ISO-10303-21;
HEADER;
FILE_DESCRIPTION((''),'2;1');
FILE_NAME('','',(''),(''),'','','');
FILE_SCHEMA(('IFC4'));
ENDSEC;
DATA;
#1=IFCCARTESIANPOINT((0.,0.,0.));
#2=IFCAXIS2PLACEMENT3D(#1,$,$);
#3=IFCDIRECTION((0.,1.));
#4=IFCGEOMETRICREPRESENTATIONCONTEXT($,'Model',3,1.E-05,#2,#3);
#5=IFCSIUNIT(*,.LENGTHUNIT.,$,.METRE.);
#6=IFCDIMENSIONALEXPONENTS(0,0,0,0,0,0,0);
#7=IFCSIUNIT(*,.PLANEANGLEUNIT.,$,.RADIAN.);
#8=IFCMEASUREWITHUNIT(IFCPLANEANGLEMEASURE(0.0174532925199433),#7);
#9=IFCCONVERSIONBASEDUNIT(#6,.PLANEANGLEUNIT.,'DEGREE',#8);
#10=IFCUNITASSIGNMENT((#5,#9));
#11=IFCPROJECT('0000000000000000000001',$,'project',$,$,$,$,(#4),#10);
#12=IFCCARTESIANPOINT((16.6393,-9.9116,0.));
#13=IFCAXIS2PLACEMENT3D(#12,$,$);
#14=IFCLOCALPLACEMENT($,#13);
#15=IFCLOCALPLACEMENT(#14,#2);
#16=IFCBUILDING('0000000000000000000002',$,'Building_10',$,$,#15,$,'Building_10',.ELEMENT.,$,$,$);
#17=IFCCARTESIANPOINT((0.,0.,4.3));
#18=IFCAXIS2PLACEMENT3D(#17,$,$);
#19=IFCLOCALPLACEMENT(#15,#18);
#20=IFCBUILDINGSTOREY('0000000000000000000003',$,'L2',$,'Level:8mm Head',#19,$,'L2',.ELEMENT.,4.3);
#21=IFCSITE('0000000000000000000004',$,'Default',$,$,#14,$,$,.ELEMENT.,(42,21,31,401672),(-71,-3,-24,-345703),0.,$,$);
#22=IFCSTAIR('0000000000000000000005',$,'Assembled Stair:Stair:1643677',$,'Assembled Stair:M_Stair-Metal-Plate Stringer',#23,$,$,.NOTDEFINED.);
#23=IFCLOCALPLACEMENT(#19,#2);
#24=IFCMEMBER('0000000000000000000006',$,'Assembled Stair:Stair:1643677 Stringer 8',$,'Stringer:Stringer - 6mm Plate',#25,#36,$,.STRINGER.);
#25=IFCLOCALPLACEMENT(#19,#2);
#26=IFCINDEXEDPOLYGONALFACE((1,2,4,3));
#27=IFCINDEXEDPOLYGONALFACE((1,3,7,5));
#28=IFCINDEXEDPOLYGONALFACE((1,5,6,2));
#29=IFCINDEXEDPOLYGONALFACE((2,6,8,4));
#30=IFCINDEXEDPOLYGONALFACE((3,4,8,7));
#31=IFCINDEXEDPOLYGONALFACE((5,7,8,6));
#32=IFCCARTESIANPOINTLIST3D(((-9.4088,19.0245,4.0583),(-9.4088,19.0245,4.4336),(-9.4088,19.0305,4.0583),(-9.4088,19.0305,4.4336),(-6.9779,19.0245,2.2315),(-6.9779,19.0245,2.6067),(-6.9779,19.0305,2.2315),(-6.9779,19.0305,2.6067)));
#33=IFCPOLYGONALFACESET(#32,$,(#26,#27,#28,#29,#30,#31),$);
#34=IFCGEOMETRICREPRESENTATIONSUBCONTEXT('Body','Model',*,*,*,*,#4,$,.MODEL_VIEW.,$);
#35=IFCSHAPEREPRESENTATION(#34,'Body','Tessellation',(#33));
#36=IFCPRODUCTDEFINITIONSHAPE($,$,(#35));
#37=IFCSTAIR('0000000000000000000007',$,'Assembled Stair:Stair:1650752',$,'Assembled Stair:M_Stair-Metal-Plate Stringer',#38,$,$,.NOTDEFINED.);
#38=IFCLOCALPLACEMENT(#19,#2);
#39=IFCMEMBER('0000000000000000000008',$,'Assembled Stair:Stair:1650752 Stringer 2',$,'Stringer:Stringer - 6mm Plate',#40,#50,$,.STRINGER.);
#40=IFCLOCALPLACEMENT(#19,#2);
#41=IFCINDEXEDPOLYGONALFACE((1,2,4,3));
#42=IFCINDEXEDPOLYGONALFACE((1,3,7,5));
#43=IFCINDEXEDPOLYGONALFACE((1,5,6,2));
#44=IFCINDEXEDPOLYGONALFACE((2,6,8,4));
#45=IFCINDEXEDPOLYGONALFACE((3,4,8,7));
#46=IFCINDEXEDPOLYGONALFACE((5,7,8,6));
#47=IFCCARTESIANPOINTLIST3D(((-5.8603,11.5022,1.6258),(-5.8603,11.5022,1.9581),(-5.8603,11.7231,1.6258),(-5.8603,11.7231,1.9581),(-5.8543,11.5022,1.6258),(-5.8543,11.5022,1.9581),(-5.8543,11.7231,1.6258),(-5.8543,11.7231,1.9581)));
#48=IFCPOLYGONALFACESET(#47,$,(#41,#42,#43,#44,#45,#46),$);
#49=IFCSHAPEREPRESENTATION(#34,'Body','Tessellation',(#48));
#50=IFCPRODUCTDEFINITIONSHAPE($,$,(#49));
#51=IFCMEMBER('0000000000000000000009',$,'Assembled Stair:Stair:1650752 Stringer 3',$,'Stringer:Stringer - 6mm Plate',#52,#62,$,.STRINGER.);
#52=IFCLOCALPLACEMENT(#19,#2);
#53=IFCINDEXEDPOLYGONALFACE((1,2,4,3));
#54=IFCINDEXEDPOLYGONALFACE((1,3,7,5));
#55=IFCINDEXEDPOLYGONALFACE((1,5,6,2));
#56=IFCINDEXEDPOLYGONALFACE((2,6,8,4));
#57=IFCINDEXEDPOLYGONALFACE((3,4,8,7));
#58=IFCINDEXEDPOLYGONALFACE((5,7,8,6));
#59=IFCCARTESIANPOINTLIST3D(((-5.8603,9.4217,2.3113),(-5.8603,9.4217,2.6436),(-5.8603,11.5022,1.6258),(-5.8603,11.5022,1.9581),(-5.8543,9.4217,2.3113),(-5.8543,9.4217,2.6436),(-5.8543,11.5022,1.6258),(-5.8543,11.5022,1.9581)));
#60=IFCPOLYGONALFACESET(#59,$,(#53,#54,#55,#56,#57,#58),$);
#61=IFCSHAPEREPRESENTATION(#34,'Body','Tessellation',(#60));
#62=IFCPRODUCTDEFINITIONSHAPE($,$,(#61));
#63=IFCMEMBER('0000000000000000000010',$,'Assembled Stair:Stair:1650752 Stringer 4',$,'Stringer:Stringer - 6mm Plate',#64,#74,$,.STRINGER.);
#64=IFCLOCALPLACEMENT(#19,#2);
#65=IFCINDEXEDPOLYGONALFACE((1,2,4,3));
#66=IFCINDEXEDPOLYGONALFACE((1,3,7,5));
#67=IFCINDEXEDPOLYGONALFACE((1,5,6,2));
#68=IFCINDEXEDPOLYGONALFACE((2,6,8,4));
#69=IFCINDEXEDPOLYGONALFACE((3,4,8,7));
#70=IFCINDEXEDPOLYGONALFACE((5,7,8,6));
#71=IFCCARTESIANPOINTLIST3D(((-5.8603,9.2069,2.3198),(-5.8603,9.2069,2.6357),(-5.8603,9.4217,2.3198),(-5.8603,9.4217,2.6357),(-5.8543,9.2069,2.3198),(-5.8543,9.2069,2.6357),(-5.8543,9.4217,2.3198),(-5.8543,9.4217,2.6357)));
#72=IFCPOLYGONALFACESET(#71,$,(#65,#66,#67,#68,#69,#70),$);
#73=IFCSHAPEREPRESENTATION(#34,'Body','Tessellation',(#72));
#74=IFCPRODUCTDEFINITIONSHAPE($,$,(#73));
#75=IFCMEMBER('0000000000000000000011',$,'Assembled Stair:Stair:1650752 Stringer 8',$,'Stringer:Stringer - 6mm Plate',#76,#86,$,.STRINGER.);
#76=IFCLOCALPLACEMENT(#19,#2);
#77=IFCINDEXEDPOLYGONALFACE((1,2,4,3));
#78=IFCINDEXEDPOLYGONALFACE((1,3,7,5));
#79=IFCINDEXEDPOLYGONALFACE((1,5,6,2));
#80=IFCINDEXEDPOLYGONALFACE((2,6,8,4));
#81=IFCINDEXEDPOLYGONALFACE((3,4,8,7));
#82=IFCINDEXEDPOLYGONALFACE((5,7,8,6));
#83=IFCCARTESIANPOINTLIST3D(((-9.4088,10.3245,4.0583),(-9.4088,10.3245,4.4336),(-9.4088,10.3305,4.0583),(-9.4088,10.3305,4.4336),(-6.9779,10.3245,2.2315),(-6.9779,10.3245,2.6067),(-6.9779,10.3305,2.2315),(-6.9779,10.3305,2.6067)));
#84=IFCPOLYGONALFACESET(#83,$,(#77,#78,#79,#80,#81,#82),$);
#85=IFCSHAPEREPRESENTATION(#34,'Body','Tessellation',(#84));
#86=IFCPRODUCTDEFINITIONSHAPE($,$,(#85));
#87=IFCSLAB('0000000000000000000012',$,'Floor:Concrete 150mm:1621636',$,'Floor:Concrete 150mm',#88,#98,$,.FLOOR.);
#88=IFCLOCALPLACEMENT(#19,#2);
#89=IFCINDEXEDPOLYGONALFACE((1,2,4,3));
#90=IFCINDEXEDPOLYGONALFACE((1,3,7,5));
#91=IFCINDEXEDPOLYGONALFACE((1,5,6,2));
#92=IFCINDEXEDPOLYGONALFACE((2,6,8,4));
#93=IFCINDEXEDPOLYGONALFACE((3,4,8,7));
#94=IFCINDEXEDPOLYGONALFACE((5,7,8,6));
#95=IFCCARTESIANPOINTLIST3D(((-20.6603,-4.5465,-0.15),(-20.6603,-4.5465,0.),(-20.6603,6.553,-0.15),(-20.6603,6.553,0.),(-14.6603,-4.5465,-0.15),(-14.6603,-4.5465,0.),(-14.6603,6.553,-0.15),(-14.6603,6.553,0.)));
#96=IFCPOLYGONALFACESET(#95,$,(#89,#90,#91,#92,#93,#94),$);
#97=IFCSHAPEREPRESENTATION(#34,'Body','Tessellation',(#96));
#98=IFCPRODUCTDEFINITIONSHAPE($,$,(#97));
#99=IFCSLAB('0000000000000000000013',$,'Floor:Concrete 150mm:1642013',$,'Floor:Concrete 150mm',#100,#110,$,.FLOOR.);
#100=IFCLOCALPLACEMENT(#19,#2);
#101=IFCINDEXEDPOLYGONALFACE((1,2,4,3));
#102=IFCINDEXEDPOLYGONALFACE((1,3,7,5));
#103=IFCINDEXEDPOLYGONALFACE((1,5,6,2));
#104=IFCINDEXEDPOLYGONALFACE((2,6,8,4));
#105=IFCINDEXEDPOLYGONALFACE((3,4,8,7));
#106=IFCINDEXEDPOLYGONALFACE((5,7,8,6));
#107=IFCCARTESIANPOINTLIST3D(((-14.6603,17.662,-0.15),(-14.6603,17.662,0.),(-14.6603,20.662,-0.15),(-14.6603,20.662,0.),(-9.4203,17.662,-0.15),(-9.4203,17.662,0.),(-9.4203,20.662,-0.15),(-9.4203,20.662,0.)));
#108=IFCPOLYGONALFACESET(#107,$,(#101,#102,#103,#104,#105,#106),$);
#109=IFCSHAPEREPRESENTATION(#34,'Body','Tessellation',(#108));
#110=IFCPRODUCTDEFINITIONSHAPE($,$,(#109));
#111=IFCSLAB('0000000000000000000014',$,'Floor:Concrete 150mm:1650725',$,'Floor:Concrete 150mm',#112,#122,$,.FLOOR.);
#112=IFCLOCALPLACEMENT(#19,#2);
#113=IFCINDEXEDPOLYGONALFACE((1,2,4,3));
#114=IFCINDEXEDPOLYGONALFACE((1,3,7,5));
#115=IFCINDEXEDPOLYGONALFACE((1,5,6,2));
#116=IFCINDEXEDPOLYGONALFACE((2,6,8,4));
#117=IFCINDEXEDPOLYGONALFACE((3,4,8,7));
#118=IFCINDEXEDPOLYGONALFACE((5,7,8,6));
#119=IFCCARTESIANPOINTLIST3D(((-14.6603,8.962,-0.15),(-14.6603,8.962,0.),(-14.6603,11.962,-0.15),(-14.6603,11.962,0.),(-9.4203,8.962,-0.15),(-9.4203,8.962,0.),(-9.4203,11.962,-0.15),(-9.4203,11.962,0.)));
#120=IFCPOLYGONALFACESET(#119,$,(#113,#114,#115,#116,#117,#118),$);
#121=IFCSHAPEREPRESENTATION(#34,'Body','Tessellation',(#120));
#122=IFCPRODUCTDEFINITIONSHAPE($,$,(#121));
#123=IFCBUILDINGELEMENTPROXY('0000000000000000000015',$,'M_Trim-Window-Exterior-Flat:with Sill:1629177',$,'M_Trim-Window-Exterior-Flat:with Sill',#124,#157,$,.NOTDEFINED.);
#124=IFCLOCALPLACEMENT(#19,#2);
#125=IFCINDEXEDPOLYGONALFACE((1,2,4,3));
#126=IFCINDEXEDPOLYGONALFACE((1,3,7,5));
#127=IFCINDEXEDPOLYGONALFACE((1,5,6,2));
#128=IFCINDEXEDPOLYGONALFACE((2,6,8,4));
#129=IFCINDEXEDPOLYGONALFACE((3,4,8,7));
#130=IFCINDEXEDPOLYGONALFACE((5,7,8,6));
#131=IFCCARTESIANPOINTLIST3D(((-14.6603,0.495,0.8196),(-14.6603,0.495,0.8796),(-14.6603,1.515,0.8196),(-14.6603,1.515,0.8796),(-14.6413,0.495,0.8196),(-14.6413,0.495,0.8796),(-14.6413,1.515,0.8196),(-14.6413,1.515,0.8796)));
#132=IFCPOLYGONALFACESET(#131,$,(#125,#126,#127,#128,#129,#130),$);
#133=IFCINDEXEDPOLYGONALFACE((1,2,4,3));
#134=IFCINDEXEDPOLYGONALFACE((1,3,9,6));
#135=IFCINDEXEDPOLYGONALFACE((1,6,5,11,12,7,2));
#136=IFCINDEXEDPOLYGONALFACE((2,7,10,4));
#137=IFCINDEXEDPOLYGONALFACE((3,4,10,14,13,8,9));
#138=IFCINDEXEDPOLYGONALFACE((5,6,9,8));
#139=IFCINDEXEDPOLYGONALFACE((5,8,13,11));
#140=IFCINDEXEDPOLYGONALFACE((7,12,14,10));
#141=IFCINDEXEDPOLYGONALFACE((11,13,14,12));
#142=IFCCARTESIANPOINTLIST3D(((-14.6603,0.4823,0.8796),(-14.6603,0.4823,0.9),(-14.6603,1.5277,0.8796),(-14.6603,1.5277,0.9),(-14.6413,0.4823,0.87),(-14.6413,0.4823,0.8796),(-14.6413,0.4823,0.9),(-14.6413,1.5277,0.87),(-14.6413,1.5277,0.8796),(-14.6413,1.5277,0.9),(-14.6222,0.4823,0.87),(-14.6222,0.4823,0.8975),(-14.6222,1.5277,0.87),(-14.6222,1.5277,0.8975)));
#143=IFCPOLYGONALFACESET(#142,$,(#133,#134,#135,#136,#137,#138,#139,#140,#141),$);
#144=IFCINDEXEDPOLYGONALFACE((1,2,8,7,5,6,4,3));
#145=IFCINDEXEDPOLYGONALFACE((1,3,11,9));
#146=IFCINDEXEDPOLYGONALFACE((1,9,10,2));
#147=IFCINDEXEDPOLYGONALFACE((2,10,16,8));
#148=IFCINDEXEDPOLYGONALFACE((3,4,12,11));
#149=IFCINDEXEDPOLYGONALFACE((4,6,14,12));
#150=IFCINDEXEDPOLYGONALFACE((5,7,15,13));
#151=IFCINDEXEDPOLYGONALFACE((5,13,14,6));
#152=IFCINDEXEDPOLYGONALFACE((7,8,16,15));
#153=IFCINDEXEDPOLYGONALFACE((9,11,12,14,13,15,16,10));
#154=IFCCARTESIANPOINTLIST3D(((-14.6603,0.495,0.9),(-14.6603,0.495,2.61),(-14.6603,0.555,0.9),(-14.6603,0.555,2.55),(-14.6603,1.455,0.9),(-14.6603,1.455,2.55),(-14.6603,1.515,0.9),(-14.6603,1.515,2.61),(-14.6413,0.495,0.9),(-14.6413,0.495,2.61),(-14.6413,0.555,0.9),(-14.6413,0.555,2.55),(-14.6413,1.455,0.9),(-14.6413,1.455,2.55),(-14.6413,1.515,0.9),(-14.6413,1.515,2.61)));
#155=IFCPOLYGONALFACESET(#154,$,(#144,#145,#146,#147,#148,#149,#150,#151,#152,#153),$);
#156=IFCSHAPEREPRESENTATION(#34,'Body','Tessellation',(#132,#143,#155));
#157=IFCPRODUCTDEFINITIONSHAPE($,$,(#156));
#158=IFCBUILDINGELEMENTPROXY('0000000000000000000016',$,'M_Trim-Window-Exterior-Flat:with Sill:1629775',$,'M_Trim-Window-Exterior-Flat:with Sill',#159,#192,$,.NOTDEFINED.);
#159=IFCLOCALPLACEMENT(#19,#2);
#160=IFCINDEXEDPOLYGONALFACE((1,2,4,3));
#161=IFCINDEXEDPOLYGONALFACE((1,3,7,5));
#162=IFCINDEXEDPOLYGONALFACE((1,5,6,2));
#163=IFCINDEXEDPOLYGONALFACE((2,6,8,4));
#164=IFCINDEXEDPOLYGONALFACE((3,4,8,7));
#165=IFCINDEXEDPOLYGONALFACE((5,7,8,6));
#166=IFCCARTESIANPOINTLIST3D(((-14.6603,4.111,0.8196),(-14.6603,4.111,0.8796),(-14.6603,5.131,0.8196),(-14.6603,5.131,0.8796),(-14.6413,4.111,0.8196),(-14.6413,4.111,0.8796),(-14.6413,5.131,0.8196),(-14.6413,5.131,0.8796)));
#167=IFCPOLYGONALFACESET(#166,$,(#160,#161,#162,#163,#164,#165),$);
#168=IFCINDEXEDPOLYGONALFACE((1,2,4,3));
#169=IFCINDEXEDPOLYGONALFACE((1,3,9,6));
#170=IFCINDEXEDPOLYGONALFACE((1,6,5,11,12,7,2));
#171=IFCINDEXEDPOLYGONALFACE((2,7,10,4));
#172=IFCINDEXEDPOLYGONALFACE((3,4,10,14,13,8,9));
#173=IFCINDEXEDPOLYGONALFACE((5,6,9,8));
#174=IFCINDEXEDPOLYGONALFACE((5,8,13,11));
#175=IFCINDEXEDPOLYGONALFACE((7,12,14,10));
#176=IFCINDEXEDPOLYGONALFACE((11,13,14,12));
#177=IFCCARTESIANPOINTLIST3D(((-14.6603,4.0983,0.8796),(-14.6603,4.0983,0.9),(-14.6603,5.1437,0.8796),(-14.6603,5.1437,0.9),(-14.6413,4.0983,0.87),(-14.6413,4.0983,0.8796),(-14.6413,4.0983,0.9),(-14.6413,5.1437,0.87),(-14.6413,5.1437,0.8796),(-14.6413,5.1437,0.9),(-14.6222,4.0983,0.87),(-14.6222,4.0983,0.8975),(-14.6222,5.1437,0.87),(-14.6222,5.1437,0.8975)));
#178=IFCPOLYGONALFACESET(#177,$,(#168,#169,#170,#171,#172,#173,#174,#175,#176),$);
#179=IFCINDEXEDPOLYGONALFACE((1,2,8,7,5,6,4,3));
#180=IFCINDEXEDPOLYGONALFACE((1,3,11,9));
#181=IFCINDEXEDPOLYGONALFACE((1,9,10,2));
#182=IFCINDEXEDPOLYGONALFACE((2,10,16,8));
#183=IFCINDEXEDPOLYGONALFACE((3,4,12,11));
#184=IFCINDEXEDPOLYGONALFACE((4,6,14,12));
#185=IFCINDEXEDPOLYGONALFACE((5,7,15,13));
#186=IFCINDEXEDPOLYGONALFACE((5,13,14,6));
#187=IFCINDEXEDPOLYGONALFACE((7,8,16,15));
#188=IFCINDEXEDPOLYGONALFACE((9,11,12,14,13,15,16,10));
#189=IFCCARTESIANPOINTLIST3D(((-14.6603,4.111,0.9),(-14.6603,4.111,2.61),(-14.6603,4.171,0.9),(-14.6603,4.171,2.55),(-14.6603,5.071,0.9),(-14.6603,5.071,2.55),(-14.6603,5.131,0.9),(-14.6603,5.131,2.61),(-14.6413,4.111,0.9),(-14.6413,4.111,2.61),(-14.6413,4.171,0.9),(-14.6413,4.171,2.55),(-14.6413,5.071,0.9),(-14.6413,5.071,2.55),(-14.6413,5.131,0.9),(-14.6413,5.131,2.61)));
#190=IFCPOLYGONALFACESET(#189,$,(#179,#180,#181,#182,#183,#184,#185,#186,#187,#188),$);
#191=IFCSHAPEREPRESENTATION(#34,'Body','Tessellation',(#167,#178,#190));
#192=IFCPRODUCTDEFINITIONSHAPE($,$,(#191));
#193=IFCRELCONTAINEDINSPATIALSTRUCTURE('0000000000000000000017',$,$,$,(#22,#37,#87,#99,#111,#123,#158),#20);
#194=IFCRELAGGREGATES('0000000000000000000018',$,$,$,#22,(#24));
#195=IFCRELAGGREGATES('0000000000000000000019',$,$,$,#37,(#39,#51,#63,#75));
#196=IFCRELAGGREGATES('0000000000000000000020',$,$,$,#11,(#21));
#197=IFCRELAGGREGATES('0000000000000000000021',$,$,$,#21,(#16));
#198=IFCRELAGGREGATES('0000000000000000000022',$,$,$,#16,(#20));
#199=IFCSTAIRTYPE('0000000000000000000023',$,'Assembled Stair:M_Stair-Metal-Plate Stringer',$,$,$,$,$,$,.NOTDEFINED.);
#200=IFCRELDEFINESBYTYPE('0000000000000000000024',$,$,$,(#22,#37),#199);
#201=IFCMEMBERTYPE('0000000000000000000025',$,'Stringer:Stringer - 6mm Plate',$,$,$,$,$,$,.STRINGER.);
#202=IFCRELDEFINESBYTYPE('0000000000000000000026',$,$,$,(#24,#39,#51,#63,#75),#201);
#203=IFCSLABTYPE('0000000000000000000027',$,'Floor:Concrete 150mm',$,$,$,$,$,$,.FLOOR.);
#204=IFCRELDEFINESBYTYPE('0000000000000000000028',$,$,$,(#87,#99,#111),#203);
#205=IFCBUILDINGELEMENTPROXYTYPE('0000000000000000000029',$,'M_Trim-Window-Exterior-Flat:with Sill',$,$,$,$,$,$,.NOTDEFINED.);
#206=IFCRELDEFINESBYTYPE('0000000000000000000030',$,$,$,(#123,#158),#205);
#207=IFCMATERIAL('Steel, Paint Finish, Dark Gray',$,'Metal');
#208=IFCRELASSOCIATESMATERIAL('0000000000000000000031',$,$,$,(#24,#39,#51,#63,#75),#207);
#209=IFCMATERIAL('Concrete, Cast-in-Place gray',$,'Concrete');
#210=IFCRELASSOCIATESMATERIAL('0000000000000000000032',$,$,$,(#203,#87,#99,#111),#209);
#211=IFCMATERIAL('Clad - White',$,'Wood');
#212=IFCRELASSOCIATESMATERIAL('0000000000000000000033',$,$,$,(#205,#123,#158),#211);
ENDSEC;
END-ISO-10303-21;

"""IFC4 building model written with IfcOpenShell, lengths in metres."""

from ifc_helpers import new_model, entity, si_unit, converted_unit, direction, frame, origin, place, context, subcontext, project, spatial, indexed_curve, outline, extrude, source, transform, mapped, material, type_object, type_shapes, element, aggregate, save


model = new_model("IFC4")

# Units and contexts
model_context = context("Model", 3, precision=1e-05, world=origin(), true_north=direction((0.0, 1.0)))
body_context = subcontext(model_context, "Body", "Model", "MODEL_VIEW")
ifc_project = project(units=[si_unit("LENGTHUNIT", "METRE"), converted_unit("PLANEANGLEUNIT", "DEGREE", entity("IfcPlaneAngleMeasure", 0.0174532925199433), si_unit("PLANEANGLEUNIT", "RADIAN"), dimensions=[0, 0, 0, 0, 0, 0, 0])], contexts=[model_context])

# Site, building, storey
site_placement = place(None, frame((16.6393, -9.9116, 0.0)))
site = spatial("IfcSite", under=ifc_project, at=site_placement, Name="Default", CompositionType="ELEMENT", RefLatitude=(42, 21, 31, 401672), RefLongitude=(-71, -3, -24, -345703), RefElevation=0.0)
building_placement = place(site_placement, origin())
building = spatial("IfcBuilding", under=site, at=building_placement, Name="Building_10", LongName="Building_10", CompositionType="ELEMENT")
storey_placement = place(building_placement, frame((0.0, 0.0, 4.3)))
storey = spatial("IfcBuildingStorey", under=building, at=storey_placement, Name="L2", ObjectType="Level:8mm Head", LongName="L2", CompositionType="ELEMENT", Elevation=4.3)

# Shared definitions
ifc_material_1 = material(Name="Concrete, Cast-in-Place gray", Category="Concrete")

# Stairs, members
stair_type = type_object("IfcStairType", Name="Assembled Stair:M_Stair-Metal-Plate Stringer", PredefinedType="NOTDEFINED")
stair_1_placement = place(storey_placement, origin())
stair_1 = element("IfcStair", 1, at=stair_1_placement, inside=storey, type_object=stair_type, Name="Assembled Stair:Stair:1643677", ObjectType="Assembled Stair:M_Stair-Metal-Plate Stringer", PredefinedType="NOTDEFINED")
ifc_material_2 = material(Name="Steel, Paint Finish, Dark Gray", Category="Metal")
member_type = type_object("IfcMemberType", Name="Stringer:Stringer - 6mm Plate", PredefinedType="STRINGER")
member_1_placement = place(stair_1_placement, origin())
member_1 = element("IfcMember", 2, at=member_1_placement, type_object=member_type, material=ifc_material_2, Name="Assembled Stair:Stair:1643677 Stringer 8", ObjectType="Stringer:Stringer - 6mm Plate", PredefinedType="STRINGER", context=body_context, shape_type="SweptSolid", body=[
    extrude(outline(indexed_curve([(-1.6331, -0.15), (1.4077, -0.15), (1.6331, 0.15), (-1.4077, 0.15), (-1.6331, -0.15)], self_intersect=False)), frame((-8.1933, 19.0245, 3.3325), z_axis=(0.0, 1.0, 0.0), x_axis=(-0.799415, 0.0, 0.600779)), (0.0, 0.0, 1.0), 0.006),
])
aggregate(stair_1, [member_1])
stair_2_placement = place(storey_placement, origin())
stair_2 = element("IfcStair", 3, at=stair_2_placement, inside=storey, type_object=stair_type, Name="Assembled Stair:Stair:1650752", ObjectType="Assembled Stair:M_Stair-Metal-Plate Stringer", PredefinedType="NOTDEFINED")
member_2_placement = place(stair_2_placement, origin())
member_2 = element("IfcMember", 4, at=member_2_placement, type_object=member_type, material=ifc_material_2, Name="Assembled Stair:Stair:1650752 Stringer 2", ObjectType="Stringer:Stringer - 6mm Plate", PredefinedType="STRINGER", context=body_context, shape_type="SweptSolid", body=[
    extrude(outline(indexed_curve([(-0.1104, -0.003), (0.1104, -0.003), (0.1104, 0.003), (-0.1104, 0.003), (-0.1104, -0.003)], self_intersect=False)), frame((-5.8573, 11.6126, 1.6258), z_axis=(0.0, 0.0, 1.0), x_axis=(0.0, -1.0, 0.0)), (0.0, 0.0, 1.0), 0.3323),
])
member_3_placement = place(stair_2_placement, origin())
member_3 = element("IfcMember", 5, at=member_3_placement, type_object=member_type, material=ifc_material_2, Name="Assembled Stair:Stair:1650752 Stringer 3", ObjectType="Stringer:Stringer - 6mm Plate", PredefinedType="STRINGER", context=body_context, shape_type="SweptSolid", body=[
    extrude(outline(indexed_curve([(-1.0433, -0.1578), (1.1473, -0.1578), (1.0433, 0.1578), (-1.1473, 0.1578), (-1.0433, -0.1578)], self_intersect=False)), frame((-5.8603, 10.462, 2.1347), z_axis=(1.0, 0.0, 0.0), x_axis=(0.0, -0.949774, 0.312936)), (0.0, 0.0, 1.0), 0.006),
])
member_4_placement = place(stair_2_placement, origin())
member_4 = element("IfcMember", 6, at=member_4_placement, type_object=member_type, material=ifc_material_2, Name="Assembled Stair:Stair:1650752 Stringer 4", ObjectType="Stringer:Stringer - 6mm Plate", PredefinedType="STRINGER", context=body_context, shape_type="SweptSolid", body=[
    extrude(outline(indexed_curve([(-0.1074, -0.003), (0.1074, -0.003), (0.1074, 0.003), (-0.1074, 0.003), (-0.1074, -0.003)], self_intersect=False)), frame((-5.8573, 9.3143, 2.3198), z_axis=(0.0, 0.0, 1.0), x_axis=(0.0, -1.0, 0.0)), (0.0, 0.0, 1.0), 0.3159),
])
member_5_placement = place(stair_2_placement, origin())
member_5 = element("IfcMember", 7, at=member_5_placement, type_object=member_type, material=ifc_material_2, Name="Assembled Stair:Stair:1650752 Stringer 8", ObjectType="Stringer:Stringer - 6mm Plate", PredefinedType="STRINGER", context=body_context, shape_type="SweptSolid", body=[
    extrude(outline(indexed_curve([(-1.6331, -0.15), (1.4077, -0.15), (1.6331, 0.15), (-1.4077, 0.15), (-1.6331, -0.15)], self_intersect=False)), frame((-8.1933, 10.3245, 3.3325), z_axis=(0.0, 1.0, 0.0), x_axis=(-0.799415, 0.0, 0.600779)), (0.0, 0.0, 1.0), 0.006),
])
aggregate(stair_2, [member_2, member_3, member_4, member_5])

# Slabs
slab_type = type_object("IfcSlabType", Name="Floor:Concrete 150mm", PredefinedType="FLOOR", material=ifc_material_1)
slab_1_placement = place(storey_placement, origin())
element("IfcSlab", 8, at=slab_1_placement, inside=storey, type_object=slab_type, material=ifc_material_1, Name="Floor:Concrete 150mm:1621636", ObjectType="Floor:Concrete 150mm", PredefinedType="FLOOR", context=body_context, shape_type="SweptSolid", body=[
    extrude(outline(indexed_curve([(-5.5498, -3.0), (5.5498, -3.0), (5.5498, 3.0), (-5.5498, 3.0), (-5.5498, -3.0)], self_intersect=False)), frame((-17.6603, 1.0032, 0.0), z_axis=(0.0, 0.0, -1.0), x_axis=(0.0, 1.0, 0.0)), (0.0, 0.0, 1.0), 0.15),
])
slab_2_placement = place(storey_placement, origin())
element("IfcSlab", 9, at=slab_2_placement, inside=storey, type_object=slab_type, material=ifc_material_1, Name="Floor:Concrete 150mm:1642013", ObjectType="Floor:Concrete 150mm", PredefinedType="FLOOR", context=body_context, shape_type="SweptSolid", body=[
    extrude(outline(indexed_curve([(-1.5, -2.62), (1.5, -2.62), (1.5, 2.62), (-1.5, 2.62), (-1.5, -2.62)], self_intersect=False)), frame((-12.0403, 19.162, 0.0), z_axis=(0.0, 0.0, -1.0), x_axis=(0.0, 1.0, 0.0)), (0.0, 0.0, 1.0), 0.15),
])
slab_3_placement = place(storey_placement, origin())
element("IfcSlab", 10, at=slab_3_placement, inside=storey, type_object=slab_type, material=ifc_material_1, Name="Floor:Concrete 150mm:1650725", ObjectType="Floor:Concrete 150mm", PredefinedType="FLOOR", context=body_context, shape_type="SweptSolid", body=[
    extrude(outline(indexed_curve([(-1.5, -2.62), (1.5, -2.62), (1.5, 2.62), (-1.5, 2.62), (-1.5, -2.62)], self_intersect=False)), frame((-12.0403, 10.462, 0.0), z_axis=(0.0, 0.0, -1.0), x_axis=(0.0, 1.0, 0.0)), (0.0, 0.0, 1.0), 0.15),
])

# Building element proxies
ifc_material_3 = material(Name="Clad - White", Category="Wood")
building_element_proxy_type_1 = type_object("IfcBuildingElementProxyType", Name="M_Trim-Window-Exterior-Flat:with Sill", PredefinedType="NOTDEFINED", material=ifc_material_3)
shared_shape_1 = source(origin(), body_context, "Body", "SweptSolid", [
    extrude(outline(indexed_curve([(-0.51, -0.03), (0.51, -0.03), (0.51, 0.03), (-0.51, 0.03), (-0.51, -0.03)], self_intersect=False)), frame((0.0, -1.7004, 0.0), z_axis=(0.0, 0.0, 1.0), x_axis=(-1.0, 0.0, 0.0)), (0.0, 0.0, 1.0), 0.0191),
    extrude(outline(indexed_curve([(-0.019, -0.0152), (0.0, -0.0152), (0.0, -0.0057), (0.019, -0.0057), (0.019, 0.0148), (0.0, 0.0148), (-0.019, 0.0123), (-0.019, -0.0152)], self_intersect=False)), frame((-0.5227, -1.6648, 0.019), z_axis=(1.0, 0.0, 0.0), x_axis=(0.0, 0.0, -1.0)), (0.0, 0.0, 1.0), 1.0454),
    extrude(outline(indexed_curve([(-0.87, -0.51), (0.84, -0.51), (0.84, -0.45), (-0.81, -0.45), (-0.81, 0.45), (0.84, 0.45), (0.84, 0.51), (-0.87, 0.51), (-0.87, -0.51)], self_intersect=False)), frame((0.0, -0.81, 0.0), z_axis=(0.0, 0.0, 1.0), x_axis=(0.0, -1.0, 0.0)), (0.0, 0.0, 1.0), 0.0191),
])
type_shapes(building_element_proxy_type_1, [shared_shape_1])
for number, where, z_axis, x_axis, name in (
    (11, (-14.6603, 1.005, 2.55), (1.0, 0.0, 0.0), (0.0, 1.0, 0.0), "M_Trim-Window-Exterior-Flat:with Sill:1629177"),
    (12, (-14.6603, 4.621, 2.55), (1.0, 0.0, 0.0), (0.0, 1.0, 0.0), "M_Trim-Window-Exterior-Flat:with Sill:1629775"),
):
    element("IfcBuildingElementProxy", number, at=place(storey_placement, frame(where, z_axis=z_axis, x_axis=x_axis)), inside=storey, type_object=building_element_proxy_type_1, material=ifc_material_3, Name=name, ObjectType="M_Trim-Window-Exterior-Flat:with Sill", PredefinedType="NOTDEFINED", context=body_context, shape_type="MappedRepresentation", body=[
        mapped(shared_shape_1, transform((0.0, 0.0, 0.0), scale=1.0)),
    ])

save(model, "model.ifc")
